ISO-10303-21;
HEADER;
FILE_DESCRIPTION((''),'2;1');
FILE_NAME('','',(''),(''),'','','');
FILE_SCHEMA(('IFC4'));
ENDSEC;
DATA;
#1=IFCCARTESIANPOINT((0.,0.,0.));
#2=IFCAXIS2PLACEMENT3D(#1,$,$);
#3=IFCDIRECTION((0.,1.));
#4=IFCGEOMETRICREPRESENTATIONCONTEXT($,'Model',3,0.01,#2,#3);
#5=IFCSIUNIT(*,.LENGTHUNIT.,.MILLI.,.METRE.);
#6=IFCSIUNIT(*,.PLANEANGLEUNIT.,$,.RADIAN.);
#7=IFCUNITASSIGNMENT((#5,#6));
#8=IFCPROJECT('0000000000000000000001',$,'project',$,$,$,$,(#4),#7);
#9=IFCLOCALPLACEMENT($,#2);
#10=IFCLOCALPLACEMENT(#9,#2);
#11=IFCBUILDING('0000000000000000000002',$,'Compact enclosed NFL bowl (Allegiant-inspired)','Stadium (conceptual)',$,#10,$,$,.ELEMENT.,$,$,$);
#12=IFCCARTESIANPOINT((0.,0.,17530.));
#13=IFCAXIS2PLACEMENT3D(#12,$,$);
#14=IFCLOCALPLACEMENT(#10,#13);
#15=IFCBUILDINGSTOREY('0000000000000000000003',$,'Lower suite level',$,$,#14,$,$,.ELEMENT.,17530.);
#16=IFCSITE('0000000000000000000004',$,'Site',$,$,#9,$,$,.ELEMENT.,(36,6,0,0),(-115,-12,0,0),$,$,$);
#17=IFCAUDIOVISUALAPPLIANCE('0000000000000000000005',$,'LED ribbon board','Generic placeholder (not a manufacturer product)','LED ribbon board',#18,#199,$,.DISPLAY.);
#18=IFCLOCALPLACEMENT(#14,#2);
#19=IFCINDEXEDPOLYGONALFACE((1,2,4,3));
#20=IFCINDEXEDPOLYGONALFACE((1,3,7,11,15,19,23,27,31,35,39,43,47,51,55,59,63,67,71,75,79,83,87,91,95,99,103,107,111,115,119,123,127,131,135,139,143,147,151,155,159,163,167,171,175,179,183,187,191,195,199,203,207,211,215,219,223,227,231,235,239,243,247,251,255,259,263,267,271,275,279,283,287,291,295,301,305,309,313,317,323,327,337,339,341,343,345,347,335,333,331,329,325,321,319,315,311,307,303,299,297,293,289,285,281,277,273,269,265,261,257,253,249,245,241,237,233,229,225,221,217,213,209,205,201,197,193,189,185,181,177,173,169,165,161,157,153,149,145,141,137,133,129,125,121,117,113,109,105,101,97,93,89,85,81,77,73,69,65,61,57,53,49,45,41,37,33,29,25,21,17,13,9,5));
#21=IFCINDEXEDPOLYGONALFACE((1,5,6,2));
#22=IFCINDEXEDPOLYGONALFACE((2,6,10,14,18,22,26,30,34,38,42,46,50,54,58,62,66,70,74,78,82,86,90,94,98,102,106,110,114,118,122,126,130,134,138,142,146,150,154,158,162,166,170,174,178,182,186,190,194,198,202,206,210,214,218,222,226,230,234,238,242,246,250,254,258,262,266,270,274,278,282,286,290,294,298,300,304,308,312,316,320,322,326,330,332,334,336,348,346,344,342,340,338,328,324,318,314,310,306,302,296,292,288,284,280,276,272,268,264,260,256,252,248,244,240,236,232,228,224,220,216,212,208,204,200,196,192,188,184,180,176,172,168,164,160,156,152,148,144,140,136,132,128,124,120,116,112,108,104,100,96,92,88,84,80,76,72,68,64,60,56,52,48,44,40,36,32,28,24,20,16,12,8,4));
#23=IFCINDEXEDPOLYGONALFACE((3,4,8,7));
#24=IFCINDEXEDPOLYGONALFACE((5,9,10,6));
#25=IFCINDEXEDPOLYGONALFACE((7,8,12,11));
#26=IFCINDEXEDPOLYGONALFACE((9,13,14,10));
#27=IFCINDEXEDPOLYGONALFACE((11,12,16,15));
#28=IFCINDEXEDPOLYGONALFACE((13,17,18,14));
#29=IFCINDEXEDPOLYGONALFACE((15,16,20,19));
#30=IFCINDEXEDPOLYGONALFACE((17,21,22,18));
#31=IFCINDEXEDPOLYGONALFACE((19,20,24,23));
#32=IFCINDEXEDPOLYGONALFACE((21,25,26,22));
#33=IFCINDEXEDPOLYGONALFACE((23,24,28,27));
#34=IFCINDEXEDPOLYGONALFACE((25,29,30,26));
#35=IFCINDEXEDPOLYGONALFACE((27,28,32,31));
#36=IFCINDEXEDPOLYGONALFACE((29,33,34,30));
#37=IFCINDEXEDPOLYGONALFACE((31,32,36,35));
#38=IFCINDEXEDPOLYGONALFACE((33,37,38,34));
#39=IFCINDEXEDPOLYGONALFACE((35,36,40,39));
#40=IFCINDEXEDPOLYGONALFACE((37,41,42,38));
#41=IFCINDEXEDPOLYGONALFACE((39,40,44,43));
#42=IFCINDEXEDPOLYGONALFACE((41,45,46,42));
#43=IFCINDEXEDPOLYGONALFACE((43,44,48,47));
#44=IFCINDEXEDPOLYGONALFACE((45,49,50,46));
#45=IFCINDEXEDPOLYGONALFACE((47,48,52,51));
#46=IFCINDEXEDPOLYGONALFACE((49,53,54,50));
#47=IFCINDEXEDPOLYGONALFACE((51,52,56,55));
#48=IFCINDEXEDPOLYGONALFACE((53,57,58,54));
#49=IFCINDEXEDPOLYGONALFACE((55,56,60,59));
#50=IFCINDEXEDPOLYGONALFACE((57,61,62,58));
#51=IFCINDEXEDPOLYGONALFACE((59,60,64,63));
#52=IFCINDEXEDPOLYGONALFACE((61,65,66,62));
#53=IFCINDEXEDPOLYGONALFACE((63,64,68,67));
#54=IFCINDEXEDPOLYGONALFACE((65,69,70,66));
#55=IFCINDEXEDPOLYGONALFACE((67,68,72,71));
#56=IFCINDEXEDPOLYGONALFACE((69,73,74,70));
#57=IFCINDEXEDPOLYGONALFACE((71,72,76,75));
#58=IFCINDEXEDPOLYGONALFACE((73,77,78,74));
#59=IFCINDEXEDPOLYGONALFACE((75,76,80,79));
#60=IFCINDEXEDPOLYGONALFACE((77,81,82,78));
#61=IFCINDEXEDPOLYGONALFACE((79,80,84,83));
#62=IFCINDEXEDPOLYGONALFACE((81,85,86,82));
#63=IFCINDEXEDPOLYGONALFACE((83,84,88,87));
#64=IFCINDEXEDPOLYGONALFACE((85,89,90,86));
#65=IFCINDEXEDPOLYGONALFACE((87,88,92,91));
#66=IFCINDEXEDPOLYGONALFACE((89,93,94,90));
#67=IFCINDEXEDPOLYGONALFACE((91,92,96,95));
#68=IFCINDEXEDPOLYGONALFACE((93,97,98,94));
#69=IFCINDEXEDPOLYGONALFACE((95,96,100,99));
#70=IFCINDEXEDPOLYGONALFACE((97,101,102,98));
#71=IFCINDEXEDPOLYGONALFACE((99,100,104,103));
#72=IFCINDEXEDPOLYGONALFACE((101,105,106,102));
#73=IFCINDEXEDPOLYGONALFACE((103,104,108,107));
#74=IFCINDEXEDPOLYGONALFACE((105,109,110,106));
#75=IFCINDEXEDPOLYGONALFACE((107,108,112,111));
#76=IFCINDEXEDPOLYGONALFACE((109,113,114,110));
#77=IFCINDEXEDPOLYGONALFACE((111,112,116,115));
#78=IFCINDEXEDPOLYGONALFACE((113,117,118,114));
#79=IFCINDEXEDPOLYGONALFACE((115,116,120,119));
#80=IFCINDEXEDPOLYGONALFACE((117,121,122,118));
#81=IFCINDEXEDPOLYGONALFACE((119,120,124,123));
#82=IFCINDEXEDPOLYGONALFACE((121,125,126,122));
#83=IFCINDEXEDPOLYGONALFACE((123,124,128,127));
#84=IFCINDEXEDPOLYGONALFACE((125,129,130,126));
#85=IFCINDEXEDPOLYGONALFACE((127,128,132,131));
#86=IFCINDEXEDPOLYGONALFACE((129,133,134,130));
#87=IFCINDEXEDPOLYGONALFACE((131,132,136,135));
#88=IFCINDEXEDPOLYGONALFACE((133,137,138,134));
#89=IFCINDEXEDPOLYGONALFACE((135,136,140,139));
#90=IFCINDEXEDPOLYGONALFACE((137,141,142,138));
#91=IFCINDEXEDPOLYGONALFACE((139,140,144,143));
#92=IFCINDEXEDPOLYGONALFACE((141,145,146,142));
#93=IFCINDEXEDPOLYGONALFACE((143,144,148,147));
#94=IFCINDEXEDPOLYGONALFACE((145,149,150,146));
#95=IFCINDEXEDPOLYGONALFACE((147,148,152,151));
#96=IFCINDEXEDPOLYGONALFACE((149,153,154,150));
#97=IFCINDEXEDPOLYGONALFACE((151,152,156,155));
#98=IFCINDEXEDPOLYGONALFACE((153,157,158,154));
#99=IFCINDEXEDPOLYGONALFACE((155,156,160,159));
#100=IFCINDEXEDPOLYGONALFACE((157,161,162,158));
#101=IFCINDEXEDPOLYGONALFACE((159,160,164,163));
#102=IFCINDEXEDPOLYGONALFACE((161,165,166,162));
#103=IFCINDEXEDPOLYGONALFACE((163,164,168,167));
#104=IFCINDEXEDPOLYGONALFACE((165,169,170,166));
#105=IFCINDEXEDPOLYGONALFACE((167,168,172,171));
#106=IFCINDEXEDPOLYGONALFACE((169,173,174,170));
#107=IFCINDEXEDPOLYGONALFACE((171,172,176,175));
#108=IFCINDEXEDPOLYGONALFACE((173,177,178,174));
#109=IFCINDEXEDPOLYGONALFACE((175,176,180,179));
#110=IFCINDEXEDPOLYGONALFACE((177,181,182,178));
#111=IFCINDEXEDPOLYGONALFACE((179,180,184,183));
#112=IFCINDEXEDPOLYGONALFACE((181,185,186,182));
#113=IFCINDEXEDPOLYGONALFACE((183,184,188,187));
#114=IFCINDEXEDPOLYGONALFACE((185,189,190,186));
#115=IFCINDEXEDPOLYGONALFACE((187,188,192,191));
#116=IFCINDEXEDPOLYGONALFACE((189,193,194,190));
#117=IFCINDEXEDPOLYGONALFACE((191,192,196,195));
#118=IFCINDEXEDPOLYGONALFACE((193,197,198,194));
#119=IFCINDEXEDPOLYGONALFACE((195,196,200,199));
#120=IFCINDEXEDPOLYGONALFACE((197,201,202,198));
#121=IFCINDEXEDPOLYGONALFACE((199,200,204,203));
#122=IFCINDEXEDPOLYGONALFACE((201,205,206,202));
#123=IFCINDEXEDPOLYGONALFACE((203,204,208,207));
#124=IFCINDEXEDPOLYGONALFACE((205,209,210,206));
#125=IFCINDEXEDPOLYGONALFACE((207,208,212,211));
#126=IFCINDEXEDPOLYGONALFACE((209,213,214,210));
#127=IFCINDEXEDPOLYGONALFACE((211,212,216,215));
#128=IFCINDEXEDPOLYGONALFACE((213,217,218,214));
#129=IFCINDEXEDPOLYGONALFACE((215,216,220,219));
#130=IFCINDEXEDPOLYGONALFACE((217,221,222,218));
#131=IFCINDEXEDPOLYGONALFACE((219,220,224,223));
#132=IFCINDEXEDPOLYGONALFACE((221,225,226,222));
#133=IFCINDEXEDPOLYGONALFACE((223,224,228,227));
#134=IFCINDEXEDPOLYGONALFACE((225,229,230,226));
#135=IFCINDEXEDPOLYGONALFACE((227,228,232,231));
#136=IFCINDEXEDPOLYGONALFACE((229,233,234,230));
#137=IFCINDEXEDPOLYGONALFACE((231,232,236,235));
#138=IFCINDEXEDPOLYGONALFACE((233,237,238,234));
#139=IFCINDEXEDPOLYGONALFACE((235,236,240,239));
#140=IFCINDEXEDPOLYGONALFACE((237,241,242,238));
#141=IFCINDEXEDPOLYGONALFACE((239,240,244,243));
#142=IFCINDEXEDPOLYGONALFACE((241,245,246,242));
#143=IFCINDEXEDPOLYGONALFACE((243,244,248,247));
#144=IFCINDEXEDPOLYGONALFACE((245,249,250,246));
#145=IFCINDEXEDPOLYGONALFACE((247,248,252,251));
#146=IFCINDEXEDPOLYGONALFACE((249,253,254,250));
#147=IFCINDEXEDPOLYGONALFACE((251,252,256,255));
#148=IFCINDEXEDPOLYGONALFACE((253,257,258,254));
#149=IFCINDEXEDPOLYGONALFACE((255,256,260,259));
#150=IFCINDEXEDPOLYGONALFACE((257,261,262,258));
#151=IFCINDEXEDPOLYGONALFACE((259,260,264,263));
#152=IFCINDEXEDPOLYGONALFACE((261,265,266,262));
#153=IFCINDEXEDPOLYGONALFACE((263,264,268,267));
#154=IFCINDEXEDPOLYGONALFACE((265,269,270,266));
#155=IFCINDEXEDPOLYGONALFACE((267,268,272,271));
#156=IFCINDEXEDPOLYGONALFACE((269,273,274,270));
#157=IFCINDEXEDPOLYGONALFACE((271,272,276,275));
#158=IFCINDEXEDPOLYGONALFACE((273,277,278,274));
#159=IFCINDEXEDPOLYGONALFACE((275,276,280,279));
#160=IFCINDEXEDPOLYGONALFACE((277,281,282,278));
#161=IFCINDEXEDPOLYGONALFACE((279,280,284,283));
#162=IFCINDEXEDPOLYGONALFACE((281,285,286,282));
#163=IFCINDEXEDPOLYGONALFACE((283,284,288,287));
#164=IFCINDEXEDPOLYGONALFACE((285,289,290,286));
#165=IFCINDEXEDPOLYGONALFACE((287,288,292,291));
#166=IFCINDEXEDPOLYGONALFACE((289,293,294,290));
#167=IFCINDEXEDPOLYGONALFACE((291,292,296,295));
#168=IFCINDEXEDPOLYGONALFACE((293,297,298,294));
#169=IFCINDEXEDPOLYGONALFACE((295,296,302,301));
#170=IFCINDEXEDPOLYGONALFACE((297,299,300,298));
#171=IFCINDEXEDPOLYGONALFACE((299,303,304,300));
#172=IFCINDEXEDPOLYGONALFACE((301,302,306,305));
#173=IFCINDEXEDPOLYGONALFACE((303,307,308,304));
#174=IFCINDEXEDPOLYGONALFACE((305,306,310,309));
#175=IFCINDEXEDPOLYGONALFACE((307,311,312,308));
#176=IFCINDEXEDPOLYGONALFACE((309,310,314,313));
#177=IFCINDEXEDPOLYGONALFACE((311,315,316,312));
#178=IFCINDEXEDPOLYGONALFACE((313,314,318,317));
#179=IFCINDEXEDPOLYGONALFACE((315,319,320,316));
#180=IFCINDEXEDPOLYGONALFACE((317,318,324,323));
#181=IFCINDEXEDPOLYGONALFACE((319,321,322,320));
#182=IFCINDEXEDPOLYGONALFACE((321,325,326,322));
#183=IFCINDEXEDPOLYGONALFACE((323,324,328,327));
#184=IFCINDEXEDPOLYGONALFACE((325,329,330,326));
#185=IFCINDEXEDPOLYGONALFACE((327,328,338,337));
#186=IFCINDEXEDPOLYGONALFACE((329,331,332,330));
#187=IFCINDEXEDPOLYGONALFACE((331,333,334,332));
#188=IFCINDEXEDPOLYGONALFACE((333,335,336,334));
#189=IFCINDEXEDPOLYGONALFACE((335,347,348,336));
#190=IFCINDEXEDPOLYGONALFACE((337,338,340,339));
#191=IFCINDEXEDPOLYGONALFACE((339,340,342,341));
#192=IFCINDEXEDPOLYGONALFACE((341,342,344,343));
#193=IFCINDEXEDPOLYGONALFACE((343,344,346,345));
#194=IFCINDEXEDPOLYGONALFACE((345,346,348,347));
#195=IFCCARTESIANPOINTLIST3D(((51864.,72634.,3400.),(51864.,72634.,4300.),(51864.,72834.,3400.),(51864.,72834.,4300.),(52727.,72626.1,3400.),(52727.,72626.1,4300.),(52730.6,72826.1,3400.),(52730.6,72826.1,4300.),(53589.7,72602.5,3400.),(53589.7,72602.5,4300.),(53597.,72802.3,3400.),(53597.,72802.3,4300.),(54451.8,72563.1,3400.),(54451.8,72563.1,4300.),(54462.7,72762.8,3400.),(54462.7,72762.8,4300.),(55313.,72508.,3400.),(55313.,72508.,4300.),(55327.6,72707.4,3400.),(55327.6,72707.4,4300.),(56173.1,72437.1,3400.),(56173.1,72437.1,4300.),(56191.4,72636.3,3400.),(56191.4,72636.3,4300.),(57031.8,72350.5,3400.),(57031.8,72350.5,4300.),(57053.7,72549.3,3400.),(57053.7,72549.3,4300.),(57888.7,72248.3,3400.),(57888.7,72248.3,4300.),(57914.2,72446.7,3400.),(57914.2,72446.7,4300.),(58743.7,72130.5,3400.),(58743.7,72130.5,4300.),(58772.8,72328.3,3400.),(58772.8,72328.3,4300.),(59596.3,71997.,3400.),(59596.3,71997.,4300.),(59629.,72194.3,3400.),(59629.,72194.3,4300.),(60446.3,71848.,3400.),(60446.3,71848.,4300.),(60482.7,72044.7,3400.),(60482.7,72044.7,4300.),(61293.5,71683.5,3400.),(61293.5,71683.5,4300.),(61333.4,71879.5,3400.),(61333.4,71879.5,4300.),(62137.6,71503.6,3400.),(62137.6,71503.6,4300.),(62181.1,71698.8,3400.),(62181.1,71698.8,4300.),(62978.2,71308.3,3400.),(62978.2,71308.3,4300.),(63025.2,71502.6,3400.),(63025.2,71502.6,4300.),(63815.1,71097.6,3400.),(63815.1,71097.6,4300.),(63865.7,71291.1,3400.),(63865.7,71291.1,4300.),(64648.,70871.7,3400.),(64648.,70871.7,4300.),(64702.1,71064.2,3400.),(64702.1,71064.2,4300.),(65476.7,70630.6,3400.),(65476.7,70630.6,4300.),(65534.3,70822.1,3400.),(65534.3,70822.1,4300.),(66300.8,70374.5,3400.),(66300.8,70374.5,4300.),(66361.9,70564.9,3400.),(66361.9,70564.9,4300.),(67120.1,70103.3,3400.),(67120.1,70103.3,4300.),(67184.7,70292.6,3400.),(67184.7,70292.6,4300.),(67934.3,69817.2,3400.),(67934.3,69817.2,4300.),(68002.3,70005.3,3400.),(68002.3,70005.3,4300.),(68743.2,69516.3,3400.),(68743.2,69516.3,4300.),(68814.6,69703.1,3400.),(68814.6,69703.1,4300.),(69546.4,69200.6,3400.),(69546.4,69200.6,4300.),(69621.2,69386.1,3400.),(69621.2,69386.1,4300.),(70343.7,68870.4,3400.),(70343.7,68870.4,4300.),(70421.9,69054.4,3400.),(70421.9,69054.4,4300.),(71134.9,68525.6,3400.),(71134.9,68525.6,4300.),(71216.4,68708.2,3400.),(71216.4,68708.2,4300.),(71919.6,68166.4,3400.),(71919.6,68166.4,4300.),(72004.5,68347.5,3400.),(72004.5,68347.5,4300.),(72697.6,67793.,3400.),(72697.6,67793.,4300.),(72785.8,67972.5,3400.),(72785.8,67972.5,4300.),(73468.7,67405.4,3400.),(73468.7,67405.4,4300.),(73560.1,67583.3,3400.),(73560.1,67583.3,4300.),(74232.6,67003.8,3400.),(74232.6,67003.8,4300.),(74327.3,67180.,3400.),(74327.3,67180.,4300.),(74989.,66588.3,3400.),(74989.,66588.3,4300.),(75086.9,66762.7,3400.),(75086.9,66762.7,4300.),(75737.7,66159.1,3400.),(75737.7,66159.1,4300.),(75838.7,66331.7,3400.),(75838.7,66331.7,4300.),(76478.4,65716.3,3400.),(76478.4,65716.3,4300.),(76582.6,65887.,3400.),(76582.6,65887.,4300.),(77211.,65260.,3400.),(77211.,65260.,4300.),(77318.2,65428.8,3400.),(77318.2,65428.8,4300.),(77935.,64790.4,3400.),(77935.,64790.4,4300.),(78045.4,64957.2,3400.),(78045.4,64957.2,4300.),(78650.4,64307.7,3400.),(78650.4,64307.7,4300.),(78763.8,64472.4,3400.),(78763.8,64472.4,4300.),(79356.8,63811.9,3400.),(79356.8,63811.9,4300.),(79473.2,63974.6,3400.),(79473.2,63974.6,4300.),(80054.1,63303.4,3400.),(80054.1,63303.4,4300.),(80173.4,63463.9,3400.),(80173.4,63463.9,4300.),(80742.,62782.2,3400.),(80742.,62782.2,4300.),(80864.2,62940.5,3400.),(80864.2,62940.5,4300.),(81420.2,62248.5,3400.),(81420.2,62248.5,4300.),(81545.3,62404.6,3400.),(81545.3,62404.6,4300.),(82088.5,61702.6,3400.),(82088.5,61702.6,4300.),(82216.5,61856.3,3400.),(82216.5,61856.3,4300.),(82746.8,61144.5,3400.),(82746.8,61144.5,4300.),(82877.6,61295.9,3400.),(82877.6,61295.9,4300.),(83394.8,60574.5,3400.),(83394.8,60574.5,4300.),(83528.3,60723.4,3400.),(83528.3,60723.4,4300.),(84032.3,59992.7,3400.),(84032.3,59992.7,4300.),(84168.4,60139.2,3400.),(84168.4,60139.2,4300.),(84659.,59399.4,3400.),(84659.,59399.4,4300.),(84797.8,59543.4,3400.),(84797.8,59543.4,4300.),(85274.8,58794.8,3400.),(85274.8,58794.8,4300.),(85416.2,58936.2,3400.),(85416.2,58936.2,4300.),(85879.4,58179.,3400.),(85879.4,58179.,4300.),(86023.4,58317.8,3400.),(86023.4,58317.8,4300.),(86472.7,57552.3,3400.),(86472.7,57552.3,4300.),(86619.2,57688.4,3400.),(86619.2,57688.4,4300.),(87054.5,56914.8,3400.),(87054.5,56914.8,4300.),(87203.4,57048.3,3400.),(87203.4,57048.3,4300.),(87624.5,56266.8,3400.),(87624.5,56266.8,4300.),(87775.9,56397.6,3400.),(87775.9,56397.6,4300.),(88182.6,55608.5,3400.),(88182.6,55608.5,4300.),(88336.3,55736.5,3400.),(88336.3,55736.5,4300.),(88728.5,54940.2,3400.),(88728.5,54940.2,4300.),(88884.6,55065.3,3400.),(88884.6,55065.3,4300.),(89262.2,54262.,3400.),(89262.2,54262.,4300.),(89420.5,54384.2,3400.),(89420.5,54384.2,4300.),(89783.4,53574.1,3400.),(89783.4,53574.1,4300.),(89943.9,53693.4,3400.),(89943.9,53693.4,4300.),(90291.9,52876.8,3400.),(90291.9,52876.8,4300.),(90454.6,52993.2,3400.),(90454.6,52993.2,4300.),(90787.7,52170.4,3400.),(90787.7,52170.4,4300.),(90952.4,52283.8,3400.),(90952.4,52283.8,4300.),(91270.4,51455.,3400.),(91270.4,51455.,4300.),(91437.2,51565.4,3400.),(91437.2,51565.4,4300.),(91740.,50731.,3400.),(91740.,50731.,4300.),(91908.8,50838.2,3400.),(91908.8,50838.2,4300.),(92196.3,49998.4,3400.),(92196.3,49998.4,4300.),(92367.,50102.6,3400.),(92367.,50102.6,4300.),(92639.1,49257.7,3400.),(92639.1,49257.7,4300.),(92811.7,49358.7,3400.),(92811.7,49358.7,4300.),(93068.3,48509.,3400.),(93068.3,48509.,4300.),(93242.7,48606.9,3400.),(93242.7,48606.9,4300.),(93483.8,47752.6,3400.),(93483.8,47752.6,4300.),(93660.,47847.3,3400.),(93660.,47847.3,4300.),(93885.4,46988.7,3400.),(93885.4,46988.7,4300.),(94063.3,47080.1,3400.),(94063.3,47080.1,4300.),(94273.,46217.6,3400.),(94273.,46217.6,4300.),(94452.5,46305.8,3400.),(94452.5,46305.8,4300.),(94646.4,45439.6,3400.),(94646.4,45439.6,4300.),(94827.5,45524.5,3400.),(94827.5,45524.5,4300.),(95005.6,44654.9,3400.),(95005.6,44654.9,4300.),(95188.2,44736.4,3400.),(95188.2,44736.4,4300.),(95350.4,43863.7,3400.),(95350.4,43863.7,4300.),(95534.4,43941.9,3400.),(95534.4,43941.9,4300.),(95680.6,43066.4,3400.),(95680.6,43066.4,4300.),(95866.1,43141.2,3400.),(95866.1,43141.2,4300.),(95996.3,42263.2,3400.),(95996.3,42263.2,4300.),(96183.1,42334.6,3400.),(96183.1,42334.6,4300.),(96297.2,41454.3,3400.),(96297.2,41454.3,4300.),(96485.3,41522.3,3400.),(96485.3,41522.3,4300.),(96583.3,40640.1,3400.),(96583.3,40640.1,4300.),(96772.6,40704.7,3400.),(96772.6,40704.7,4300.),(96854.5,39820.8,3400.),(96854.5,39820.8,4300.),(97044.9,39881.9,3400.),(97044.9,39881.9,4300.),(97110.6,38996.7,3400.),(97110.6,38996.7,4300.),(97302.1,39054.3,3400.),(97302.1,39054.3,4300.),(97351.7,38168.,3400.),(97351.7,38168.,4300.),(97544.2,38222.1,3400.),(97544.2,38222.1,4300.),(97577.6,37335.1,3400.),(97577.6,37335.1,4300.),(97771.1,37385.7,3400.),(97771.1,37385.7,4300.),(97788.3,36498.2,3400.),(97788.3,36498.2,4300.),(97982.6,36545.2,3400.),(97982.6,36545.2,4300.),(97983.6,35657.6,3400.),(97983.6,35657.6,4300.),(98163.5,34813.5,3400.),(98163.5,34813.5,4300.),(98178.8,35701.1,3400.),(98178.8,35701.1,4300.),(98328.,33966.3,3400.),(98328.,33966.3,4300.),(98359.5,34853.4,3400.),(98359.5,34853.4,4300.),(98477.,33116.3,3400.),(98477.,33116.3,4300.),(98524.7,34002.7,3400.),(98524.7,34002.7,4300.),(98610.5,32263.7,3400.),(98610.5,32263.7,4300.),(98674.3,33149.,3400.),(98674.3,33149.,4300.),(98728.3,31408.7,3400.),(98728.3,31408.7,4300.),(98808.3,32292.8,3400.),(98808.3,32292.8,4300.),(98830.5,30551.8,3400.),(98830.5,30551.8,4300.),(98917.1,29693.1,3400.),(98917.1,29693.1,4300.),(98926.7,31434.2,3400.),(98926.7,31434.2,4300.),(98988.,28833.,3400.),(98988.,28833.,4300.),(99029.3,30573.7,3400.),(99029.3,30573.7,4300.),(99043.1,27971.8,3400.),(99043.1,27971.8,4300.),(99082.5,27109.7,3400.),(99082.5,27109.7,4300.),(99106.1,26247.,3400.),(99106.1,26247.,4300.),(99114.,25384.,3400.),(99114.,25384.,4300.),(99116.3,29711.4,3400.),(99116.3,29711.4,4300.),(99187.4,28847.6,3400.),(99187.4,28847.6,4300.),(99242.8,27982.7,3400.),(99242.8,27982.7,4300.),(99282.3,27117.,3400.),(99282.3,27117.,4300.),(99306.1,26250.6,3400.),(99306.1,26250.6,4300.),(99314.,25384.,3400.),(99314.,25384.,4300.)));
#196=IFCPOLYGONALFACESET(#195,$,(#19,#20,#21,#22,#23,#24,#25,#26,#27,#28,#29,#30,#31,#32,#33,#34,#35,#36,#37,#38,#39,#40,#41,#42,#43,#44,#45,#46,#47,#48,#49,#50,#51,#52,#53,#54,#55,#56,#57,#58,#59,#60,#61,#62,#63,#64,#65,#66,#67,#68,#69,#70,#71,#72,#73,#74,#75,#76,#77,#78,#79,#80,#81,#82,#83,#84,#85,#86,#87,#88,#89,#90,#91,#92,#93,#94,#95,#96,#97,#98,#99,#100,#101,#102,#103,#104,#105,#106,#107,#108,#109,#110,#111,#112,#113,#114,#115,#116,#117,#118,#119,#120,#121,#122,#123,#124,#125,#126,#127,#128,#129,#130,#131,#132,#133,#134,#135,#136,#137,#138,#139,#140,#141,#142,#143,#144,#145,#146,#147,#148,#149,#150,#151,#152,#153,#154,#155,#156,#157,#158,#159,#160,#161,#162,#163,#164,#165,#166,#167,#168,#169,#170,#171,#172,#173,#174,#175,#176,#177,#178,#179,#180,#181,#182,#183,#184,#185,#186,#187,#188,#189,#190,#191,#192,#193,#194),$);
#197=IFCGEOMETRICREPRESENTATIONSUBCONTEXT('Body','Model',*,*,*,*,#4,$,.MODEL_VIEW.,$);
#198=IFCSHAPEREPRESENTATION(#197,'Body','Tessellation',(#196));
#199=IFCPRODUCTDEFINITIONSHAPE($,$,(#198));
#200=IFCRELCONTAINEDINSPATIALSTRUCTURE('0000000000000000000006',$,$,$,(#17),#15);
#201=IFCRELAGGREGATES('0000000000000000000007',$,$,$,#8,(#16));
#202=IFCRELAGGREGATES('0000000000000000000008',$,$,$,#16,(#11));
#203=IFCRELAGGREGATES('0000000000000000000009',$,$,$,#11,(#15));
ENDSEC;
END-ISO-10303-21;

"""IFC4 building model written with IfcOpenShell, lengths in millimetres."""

from ifc_helpers import new_model, si_unit, direction, frame, origin, place, context, subcontext, project, spatial, line, arc, indexed_curve, outline, extrude, element, save


model = new_model("IFC4")

# Units and contexts
model_context = context("Model", 3, precision=0.01, world=origin(), true_north=direction((0.0, 1.0)))
body_context = subcontext(model_context, "Body", "Model", "MODEL_VIEW")
ifc_project = project(units=[si_unit("LENGTHUNIT", "METRE", prefix="MILLI"), si_unit("PLANEANGLEUNIT", "RADIAN")], contexts=[model_context])

# Site, building, storey
site_placement = place(None, origin())
site = spatial("IfcSite", under=ifc_project, at=site_placement, Name="Site", CompositionType="ELEMENT", RefLatitude=(36, 6, 0, 0), RefLongitude=(-115, -12, 0, 0))
building_placement = place(site_placement, origin())
building = spatial("IfcBuilding", under=site, at=building_placement, Name="Compact enclosed NFL bowl (Allegiant-inspired)", Description="Stadium (conceptual)", CompositionType="ELEMENT")
storey_placement = place(building_placement, frame((0.0, 0.0, 17530.0)))
storey = spatial("IfcBuildingStorey", under=building, at=storey_placement, Name="Lower suite level", CompositionType="ELEMENT", Elevation=17530.0)

# Shared definitions
placement = place(storey_placement, frame((0.0, 0.0, -17530.0)))

# Audio visual appliance
element("IfcAudioVisualAppliance", 1, at=placement, inside=storey, Name="LED ribbon board", Description="Generic placeholder (not a manufacturer product)", ObjectType="LED ribbon board", PredefinedType="DISPLAY", context=body_context, shape_type="SweptSolid", body=[
    extrude(outline(indexed_curve([(99114.0, 25384.0), (85274.8, 58794.8), (51864.0, 72634.0), (51864.0, 72834.0), (85416.2, 58936.2), (99314.0, 25384.0)], segments=[arc(1, 2, 3), line(3, 4), arc(4, 5, 6), line(6, 1)], self_intersect=False)), frame((0.0, 0.0, 20930.0)), (0.0, 0.0, 1.0), 900.0),
])

save(model, "model.ifc")
